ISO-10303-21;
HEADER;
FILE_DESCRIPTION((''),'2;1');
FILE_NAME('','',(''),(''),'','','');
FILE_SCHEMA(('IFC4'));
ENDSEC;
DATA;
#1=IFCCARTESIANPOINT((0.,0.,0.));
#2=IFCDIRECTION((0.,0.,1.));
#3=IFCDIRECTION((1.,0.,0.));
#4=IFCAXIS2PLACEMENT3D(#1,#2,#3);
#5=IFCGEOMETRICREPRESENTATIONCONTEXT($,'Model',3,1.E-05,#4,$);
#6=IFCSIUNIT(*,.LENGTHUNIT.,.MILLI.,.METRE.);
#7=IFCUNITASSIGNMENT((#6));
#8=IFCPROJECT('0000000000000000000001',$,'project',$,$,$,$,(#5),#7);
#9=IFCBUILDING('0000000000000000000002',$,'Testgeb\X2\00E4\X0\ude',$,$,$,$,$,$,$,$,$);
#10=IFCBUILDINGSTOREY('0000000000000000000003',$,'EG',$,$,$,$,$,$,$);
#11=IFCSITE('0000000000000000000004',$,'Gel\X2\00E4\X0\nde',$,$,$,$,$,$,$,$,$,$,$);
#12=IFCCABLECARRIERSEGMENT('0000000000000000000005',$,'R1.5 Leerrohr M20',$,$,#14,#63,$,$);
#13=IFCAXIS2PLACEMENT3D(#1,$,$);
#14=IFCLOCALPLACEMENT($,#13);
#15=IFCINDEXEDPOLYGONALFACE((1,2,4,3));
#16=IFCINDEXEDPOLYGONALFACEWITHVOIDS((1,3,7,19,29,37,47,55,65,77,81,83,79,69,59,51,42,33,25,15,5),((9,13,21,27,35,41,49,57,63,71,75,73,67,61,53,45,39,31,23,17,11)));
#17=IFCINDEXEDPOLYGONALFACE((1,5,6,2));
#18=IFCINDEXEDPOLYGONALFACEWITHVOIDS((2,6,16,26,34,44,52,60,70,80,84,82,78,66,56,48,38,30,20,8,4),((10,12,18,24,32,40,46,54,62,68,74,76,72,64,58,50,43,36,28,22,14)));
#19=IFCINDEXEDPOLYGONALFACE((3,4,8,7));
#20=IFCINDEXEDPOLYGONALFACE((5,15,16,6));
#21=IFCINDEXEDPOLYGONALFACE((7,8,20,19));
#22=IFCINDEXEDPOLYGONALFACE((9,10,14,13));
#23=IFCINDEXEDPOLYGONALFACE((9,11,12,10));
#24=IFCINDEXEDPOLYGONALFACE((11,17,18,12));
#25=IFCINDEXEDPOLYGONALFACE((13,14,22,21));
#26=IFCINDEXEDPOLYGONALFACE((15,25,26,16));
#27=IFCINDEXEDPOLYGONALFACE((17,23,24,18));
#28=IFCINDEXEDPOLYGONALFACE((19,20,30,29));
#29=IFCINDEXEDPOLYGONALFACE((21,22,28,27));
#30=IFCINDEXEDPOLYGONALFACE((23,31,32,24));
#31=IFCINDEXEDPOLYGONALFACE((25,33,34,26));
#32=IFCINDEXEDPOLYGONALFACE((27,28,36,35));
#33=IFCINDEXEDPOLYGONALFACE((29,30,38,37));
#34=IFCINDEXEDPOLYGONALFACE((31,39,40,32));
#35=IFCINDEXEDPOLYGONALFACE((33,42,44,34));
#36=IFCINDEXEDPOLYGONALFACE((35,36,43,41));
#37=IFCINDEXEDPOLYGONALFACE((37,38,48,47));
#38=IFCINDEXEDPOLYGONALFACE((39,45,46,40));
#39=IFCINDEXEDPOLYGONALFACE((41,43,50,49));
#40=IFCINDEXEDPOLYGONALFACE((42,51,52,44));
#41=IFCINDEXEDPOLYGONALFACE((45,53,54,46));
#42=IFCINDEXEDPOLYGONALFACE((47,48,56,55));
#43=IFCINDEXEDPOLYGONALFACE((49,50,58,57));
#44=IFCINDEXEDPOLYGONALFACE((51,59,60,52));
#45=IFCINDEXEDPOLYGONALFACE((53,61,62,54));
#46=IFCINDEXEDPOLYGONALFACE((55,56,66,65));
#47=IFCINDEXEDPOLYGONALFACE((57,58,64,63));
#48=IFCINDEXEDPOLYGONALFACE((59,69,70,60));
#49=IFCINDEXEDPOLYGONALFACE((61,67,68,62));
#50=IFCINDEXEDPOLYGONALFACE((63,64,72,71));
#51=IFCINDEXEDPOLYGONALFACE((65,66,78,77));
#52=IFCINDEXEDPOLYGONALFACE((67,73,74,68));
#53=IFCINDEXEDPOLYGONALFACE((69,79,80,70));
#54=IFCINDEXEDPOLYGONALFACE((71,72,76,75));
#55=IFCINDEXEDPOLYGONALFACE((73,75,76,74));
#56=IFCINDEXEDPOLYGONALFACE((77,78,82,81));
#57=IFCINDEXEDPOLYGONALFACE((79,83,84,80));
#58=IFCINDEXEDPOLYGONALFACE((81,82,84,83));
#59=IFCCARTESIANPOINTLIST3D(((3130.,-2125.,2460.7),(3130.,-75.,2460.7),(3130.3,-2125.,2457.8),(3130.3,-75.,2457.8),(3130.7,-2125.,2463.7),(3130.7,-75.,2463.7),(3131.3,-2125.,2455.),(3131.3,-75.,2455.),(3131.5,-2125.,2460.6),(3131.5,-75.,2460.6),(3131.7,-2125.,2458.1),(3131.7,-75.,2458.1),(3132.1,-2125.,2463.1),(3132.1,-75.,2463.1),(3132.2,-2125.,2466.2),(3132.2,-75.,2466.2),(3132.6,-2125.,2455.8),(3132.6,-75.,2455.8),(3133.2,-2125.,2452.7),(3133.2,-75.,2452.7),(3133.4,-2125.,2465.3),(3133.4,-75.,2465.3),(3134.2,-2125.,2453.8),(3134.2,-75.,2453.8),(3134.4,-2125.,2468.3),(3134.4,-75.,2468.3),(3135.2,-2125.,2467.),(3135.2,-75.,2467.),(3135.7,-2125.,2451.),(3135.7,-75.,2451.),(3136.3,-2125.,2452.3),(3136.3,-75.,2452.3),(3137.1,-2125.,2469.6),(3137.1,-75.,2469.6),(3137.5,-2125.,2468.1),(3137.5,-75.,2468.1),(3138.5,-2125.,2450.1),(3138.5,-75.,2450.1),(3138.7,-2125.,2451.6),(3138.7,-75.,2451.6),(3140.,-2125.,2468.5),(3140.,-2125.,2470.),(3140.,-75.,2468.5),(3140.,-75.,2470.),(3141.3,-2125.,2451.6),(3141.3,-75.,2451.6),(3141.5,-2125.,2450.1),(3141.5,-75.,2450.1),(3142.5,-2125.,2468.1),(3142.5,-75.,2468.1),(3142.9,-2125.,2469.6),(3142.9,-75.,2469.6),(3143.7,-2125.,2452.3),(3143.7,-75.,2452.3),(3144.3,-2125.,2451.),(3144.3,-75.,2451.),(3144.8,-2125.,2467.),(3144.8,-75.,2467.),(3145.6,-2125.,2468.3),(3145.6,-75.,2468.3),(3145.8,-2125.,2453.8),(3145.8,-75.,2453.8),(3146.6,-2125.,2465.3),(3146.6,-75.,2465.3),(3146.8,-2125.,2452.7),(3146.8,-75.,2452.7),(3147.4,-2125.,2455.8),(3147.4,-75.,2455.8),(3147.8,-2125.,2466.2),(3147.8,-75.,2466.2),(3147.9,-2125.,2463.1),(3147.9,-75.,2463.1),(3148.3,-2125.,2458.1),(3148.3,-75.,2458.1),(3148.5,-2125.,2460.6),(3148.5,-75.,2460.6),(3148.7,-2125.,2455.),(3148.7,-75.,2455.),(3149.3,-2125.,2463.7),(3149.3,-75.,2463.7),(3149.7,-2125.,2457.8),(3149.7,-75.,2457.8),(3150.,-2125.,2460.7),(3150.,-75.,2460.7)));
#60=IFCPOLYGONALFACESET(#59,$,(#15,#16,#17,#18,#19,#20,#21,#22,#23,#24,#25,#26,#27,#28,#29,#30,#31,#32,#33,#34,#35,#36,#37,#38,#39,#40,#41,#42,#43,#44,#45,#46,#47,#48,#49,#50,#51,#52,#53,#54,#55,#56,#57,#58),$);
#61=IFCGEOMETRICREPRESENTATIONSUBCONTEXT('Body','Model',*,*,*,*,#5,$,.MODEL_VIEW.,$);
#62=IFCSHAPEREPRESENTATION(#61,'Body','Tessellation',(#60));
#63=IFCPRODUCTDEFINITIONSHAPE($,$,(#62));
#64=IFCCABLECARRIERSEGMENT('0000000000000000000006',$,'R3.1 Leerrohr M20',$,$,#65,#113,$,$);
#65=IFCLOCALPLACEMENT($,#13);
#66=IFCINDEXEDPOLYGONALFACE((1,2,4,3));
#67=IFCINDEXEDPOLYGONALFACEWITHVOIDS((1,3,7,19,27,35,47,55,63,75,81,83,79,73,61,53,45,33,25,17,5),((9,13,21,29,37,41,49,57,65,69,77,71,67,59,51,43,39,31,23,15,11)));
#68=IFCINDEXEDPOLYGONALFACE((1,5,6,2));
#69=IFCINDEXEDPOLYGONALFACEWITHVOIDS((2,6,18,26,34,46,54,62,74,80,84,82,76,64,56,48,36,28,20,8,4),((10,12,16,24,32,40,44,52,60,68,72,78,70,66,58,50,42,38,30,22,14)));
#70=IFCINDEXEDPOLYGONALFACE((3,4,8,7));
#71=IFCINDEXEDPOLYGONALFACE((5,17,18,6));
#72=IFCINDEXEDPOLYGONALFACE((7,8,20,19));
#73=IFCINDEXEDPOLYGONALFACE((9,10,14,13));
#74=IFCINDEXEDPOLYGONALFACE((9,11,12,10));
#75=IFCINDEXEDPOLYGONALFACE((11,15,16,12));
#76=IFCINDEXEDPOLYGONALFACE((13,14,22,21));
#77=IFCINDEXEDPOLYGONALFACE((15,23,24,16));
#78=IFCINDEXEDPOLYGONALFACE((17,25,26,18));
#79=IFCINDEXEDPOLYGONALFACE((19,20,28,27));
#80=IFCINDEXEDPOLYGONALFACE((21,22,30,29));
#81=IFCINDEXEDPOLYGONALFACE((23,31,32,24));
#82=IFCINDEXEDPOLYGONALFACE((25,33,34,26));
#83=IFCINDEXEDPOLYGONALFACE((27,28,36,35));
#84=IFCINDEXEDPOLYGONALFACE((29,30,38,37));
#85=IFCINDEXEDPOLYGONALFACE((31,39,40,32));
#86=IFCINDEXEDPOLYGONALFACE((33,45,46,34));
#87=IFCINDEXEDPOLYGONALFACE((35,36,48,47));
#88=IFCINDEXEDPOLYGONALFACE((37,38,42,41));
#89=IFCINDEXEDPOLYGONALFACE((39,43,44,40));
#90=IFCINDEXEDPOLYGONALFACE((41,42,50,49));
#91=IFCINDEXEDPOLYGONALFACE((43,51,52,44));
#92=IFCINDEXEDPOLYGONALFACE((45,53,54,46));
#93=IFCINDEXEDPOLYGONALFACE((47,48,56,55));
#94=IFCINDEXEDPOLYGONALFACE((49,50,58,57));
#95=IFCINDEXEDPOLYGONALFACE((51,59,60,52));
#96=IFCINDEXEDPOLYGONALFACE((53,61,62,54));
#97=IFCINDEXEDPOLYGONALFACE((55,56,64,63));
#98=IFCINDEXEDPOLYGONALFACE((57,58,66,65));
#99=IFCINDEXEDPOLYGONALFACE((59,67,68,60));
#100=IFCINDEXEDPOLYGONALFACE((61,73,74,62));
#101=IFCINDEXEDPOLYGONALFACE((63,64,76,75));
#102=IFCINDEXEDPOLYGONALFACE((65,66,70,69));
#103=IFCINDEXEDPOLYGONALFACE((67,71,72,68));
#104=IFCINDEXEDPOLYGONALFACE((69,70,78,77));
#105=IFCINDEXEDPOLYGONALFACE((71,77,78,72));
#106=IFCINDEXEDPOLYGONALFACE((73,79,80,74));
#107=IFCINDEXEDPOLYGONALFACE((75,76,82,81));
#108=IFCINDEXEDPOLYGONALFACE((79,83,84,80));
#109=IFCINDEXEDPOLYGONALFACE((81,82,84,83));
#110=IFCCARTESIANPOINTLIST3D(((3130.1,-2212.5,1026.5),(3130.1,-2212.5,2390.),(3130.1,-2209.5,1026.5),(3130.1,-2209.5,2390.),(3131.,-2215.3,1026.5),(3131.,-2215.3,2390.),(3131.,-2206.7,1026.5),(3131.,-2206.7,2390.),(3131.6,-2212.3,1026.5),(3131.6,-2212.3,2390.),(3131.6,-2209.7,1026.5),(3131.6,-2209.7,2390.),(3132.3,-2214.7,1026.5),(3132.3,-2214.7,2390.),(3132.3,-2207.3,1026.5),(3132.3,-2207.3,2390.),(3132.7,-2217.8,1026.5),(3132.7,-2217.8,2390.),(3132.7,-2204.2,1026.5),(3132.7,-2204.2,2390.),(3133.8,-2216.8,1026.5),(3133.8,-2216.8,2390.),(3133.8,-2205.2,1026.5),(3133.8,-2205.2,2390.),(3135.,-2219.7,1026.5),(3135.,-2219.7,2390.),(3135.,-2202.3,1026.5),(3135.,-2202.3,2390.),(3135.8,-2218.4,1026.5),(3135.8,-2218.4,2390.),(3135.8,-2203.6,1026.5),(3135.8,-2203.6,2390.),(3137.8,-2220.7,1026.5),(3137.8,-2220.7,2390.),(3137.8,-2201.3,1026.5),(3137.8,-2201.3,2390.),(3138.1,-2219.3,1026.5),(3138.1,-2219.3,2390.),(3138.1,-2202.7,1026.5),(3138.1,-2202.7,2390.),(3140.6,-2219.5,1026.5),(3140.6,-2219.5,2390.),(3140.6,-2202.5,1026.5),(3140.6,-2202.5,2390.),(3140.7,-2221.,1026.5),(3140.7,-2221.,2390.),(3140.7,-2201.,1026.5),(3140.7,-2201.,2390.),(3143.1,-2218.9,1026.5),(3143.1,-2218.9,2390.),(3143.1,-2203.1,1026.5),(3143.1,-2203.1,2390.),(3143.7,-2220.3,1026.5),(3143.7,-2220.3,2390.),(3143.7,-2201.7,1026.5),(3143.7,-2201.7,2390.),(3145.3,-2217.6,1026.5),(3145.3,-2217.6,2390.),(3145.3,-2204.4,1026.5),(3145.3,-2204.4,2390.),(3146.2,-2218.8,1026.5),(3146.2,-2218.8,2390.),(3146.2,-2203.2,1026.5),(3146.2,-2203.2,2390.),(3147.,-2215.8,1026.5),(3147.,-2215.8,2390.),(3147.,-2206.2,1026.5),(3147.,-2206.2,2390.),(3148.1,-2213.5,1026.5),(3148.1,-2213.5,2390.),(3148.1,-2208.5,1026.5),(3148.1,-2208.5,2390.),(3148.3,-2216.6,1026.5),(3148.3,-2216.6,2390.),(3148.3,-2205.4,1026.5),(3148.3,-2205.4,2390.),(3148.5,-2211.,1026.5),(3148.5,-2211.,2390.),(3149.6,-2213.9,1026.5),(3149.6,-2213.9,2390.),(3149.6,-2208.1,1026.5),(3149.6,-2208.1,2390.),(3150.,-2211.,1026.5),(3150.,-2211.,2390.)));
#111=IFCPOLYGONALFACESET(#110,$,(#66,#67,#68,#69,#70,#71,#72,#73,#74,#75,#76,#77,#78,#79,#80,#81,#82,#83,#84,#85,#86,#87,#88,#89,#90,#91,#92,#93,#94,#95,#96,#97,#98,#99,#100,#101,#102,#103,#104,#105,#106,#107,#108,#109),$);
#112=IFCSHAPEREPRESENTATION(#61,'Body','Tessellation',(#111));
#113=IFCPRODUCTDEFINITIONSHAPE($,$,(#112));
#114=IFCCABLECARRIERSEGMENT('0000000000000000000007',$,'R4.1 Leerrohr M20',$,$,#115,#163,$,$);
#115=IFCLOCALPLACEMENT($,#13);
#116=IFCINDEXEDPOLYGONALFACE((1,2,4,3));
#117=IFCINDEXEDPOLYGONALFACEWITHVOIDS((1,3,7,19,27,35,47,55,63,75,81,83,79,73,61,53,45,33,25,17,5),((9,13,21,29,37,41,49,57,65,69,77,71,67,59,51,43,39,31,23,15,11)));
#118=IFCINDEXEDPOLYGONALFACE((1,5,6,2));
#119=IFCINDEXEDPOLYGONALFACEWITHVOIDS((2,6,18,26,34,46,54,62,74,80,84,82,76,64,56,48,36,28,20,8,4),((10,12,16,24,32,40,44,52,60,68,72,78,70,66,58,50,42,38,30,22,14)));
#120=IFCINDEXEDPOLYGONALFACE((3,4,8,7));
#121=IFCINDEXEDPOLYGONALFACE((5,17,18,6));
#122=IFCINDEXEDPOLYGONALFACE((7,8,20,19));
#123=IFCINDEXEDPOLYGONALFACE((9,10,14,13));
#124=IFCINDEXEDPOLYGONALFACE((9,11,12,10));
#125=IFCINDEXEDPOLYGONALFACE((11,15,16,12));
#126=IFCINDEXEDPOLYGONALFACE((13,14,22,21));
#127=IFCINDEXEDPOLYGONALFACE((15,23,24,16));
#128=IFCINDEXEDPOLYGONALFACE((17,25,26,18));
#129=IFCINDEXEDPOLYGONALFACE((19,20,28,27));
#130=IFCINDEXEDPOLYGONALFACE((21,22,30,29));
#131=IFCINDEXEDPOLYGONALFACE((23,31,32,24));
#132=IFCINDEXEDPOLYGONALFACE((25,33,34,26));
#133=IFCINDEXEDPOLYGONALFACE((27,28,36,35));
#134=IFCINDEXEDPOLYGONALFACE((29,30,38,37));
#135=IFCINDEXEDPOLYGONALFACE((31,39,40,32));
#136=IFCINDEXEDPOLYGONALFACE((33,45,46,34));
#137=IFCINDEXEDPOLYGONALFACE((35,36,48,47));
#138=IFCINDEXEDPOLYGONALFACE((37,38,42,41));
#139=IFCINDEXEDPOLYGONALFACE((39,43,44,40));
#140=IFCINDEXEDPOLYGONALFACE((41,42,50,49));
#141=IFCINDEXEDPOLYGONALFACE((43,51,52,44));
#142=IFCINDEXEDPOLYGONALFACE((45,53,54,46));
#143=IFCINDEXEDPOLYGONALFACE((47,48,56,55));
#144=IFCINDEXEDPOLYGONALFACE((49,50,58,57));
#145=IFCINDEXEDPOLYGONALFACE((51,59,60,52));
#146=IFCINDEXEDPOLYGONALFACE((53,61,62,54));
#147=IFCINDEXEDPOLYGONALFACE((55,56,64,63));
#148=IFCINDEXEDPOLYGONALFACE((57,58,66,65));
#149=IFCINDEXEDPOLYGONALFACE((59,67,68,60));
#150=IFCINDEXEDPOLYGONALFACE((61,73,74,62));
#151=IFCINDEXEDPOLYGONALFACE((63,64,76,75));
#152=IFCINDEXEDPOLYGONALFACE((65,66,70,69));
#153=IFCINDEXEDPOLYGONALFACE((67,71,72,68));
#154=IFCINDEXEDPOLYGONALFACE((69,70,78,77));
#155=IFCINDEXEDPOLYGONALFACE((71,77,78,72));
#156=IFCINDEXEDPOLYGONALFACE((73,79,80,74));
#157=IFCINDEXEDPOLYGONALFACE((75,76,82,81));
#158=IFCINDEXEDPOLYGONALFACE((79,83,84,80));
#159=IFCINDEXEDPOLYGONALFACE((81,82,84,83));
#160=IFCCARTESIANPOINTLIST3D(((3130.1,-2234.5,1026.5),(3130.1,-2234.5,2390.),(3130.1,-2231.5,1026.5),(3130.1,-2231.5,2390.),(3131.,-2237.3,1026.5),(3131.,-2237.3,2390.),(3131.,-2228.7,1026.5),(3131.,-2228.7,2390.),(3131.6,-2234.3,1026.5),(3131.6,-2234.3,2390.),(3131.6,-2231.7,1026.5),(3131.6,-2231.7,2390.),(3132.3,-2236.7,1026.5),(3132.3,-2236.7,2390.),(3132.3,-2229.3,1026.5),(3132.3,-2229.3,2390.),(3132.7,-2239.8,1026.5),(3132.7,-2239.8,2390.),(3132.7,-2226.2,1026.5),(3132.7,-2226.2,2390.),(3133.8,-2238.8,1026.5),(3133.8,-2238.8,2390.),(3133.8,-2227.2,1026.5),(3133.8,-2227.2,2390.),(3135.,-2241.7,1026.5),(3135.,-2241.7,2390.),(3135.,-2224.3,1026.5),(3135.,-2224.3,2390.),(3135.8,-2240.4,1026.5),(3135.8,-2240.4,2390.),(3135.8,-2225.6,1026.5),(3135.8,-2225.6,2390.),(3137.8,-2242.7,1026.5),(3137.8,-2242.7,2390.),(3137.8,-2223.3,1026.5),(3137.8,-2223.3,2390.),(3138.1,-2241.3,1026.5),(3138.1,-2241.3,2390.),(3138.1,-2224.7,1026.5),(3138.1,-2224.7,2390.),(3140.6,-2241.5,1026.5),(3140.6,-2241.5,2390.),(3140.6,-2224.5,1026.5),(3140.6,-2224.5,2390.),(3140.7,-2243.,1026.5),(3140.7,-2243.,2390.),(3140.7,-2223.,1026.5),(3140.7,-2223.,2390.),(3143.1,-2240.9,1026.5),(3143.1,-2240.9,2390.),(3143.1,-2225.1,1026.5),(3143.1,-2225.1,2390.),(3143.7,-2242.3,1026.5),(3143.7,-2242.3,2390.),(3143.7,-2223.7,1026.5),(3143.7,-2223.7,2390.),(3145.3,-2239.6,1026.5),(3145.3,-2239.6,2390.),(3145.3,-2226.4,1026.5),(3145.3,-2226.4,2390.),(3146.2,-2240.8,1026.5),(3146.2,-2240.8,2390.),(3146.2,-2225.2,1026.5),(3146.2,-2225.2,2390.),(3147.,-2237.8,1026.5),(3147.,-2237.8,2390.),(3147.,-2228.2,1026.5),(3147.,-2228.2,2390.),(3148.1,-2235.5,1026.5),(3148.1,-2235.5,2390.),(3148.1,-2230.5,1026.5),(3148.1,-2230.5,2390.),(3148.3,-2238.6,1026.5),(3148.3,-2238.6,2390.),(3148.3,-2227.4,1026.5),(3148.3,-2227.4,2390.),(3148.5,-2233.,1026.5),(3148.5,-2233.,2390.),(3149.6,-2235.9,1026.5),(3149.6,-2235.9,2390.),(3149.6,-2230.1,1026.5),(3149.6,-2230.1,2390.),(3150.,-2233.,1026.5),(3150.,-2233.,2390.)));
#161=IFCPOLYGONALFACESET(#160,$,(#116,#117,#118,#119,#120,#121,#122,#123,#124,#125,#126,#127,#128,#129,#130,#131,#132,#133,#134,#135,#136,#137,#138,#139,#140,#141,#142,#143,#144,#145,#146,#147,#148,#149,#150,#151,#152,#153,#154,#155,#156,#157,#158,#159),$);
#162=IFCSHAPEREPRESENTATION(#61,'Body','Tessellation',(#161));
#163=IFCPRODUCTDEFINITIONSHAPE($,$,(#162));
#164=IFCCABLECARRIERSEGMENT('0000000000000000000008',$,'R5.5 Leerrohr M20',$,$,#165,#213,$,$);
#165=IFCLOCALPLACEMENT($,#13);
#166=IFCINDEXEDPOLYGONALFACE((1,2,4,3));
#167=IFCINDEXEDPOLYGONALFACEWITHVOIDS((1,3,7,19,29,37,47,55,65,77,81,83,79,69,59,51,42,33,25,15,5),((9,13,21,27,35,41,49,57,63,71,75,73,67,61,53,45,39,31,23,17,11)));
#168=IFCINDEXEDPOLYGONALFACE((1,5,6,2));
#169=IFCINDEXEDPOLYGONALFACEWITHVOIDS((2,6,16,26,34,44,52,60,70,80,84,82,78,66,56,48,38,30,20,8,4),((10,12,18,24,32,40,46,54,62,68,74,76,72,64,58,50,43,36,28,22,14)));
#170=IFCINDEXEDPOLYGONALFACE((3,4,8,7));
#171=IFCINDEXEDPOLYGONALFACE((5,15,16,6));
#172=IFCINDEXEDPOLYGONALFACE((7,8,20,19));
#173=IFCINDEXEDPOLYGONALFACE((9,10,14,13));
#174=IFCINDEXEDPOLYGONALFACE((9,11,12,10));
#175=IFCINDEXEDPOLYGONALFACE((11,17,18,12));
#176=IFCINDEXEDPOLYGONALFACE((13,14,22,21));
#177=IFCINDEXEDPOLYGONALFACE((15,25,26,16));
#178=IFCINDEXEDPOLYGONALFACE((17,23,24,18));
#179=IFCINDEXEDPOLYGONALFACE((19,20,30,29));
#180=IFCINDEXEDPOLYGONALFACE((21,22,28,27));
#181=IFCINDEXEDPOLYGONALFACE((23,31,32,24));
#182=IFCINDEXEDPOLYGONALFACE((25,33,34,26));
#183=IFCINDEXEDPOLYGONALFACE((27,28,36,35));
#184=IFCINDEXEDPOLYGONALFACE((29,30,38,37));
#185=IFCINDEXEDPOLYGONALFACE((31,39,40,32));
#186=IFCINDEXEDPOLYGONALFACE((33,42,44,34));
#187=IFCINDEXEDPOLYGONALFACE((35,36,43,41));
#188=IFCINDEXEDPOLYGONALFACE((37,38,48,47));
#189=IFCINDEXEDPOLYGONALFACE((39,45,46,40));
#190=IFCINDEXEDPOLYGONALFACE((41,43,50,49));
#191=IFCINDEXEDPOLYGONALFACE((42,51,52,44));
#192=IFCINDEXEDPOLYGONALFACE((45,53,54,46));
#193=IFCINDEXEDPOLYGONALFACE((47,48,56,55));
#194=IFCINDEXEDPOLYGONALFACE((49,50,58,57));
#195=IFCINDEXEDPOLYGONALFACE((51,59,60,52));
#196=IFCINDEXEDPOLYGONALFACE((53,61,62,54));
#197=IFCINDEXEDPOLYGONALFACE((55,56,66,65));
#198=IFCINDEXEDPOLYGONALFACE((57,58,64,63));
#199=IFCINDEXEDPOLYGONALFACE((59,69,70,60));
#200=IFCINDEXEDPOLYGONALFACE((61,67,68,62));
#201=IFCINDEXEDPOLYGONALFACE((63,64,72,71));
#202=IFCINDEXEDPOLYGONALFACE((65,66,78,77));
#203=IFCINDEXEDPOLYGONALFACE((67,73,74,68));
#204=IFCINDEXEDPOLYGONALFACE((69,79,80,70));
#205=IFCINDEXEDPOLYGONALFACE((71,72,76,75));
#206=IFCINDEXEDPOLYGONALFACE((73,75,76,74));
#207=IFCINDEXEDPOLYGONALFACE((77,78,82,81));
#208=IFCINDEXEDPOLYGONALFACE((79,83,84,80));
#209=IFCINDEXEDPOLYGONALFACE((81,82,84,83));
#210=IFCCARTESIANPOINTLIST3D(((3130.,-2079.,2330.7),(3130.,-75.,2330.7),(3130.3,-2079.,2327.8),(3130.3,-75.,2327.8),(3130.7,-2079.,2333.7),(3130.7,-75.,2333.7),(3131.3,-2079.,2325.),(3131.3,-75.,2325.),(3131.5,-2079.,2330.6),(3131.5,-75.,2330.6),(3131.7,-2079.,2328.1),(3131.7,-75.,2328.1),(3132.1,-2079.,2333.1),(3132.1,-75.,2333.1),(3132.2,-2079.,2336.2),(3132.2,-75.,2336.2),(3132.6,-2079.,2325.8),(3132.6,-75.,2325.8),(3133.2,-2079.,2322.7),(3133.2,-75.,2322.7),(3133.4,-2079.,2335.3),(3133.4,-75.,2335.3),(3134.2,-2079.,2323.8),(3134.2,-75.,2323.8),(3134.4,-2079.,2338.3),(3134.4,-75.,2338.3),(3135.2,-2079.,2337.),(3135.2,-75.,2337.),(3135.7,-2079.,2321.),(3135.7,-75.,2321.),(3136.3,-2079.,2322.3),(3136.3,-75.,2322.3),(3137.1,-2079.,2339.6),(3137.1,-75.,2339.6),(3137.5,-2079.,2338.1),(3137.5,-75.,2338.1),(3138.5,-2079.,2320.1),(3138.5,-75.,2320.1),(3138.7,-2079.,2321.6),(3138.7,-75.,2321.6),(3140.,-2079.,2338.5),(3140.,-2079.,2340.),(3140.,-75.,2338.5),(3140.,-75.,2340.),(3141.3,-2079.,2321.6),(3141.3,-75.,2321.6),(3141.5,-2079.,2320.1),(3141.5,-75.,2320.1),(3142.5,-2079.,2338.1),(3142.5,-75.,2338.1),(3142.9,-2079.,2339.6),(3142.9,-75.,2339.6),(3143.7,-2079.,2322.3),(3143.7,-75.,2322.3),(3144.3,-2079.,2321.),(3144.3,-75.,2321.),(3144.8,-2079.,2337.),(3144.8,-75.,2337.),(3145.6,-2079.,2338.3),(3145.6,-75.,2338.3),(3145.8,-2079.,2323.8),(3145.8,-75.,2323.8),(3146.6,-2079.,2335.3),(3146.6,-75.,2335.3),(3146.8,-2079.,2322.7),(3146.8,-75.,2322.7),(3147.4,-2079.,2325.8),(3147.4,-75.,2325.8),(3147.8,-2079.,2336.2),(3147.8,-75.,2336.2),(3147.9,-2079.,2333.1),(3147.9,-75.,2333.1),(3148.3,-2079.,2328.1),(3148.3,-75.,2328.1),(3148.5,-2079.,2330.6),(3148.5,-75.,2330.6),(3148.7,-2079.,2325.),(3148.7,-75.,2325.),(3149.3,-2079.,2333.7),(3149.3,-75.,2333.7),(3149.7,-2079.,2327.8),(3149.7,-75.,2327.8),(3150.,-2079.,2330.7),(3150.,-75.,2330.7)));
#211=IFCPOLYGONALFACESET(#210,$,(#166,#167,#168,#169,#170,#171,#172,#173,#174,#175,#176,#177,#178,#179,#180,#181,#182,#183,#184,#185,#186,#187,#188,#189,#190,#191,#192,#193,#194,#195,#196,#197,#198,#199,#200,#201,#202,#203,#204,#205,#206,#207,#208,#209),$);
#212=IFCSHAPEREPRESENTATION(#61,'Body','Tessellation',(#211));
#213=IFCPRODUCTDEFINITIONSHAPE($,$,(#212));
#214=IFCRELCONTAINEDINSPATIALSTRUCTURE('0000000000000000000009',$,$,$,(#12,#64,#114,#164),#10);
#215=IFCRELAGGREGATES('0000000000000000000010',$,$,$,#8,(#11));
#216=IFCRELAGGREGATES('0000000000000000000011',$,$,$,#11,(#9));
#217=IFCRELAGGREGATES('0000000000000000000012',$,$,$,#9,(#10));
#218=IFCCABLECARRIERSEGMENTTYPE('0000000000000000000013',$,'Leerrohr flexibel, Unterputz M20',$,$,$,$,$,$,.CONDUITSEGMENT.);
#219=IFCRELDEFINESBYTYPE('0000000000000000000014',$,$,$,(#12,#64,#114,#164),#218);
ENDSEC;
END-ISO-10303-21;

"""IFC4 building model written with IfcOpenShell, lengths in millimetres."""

from ifc_helpers import new_model, si_unit, frame, origin_with_axes, place, context, subcontext, project, spatial, hollow_circle, extrude, type_object, element, save


model = new_model("IFC4")

# Units and contexts
model_context = context("Model", 3, precision=1e-05, world=origin_with_axes())
body_context = subcontext(model_context, "Body", "Model", "MODEL_VIEW")
ifc_project = project(units=[si_unit("LENGTHUNIT", "METRE", prefix="MILLI")], contexts=[model_context])

# Site, building, storey
site = spatial("IfcSite", under=ifc_project, Name="Gelände")
building = spatial("IfcBuilding", under=site, Name="Testgebäude")
storey = spatial("IfcBuildingStorey", under=building, Name="EG")

# Cable carrier segments
cable_carrier_segment_type_1 = type_object("IfcCableCarrierSegmentType", Name="Leerrohr flexibel, Unterputz M20", PredefinedType="CONDUITSEGMENT")
cable_carrier_segment_1_placement = place(None, frame((3140.0, -75.0, 2460.0), z_axis=(0.0, -1.0, 0.0), x_axis=(0.0, 0.0, 1.0)))
element("IfcCableCarrierSegment", 1, at=cable_carrier_segment_1_placement, inside=storey, type_object=cable_carrier_segment_type_1, Name="R1.5 Leerrohr M20", context=body_context, shape_type="SweptSolid", body=[
    extrude(hollow_circle(Radius=10.0, WallThickness=1.5), None, (0.0, 0.0, 1.0), 2050.0),
])
for number, where, z_axis, x_axis, name in (
    (2, (3140.0, -2211.0, 1026.5), (0.0, 0.0, 1.0), (1.0, 0.0, 0.0), "R3.1 Leerrohr M20"),
    (3, (3140.0, -2233.0, 1026.5), (0.0, 0.0, 1.0), (1.0, 0.0, 0.0), "R4.1 Leerrohr M20"),
):
    element("IfcCableCarrierSegment", number, at=place(None, frame(where, z_axis=z_axis, x_axis=x_axis)), inside=storey, type_object=cable_carrier_segment_type_1, Name=name, context=body_context, shape_type="SweptSolid", body=[
        extrude(hollow_circle(Radius=10.0, WallThickness=1.5), None, (0.0, 0.0, 1.0), 1363.5),
    ])
cable_carrier_segment_2_placement = place(None, frame((3140.0, -75.0, 2330.0), z_axis=(0.0, -1.0, 0.0), x_axis=(0.0, 0.0, 1.0)))
element("IfcCableCarrierSegment", 4, at=cable_carrier_segment_2_placement, inside=storey, type_object=cable_carrier_segment_type_1, Name="R5.5 Leerrohr M20", context=body_context, shape_type="SweptSolid", body=[
    extrude(hollow_circle(Radius=10.0, WallThickness=1.5), None, (0.0, 0.0, 1.0), 2004.0),
])

save(model, "model.ifc")
